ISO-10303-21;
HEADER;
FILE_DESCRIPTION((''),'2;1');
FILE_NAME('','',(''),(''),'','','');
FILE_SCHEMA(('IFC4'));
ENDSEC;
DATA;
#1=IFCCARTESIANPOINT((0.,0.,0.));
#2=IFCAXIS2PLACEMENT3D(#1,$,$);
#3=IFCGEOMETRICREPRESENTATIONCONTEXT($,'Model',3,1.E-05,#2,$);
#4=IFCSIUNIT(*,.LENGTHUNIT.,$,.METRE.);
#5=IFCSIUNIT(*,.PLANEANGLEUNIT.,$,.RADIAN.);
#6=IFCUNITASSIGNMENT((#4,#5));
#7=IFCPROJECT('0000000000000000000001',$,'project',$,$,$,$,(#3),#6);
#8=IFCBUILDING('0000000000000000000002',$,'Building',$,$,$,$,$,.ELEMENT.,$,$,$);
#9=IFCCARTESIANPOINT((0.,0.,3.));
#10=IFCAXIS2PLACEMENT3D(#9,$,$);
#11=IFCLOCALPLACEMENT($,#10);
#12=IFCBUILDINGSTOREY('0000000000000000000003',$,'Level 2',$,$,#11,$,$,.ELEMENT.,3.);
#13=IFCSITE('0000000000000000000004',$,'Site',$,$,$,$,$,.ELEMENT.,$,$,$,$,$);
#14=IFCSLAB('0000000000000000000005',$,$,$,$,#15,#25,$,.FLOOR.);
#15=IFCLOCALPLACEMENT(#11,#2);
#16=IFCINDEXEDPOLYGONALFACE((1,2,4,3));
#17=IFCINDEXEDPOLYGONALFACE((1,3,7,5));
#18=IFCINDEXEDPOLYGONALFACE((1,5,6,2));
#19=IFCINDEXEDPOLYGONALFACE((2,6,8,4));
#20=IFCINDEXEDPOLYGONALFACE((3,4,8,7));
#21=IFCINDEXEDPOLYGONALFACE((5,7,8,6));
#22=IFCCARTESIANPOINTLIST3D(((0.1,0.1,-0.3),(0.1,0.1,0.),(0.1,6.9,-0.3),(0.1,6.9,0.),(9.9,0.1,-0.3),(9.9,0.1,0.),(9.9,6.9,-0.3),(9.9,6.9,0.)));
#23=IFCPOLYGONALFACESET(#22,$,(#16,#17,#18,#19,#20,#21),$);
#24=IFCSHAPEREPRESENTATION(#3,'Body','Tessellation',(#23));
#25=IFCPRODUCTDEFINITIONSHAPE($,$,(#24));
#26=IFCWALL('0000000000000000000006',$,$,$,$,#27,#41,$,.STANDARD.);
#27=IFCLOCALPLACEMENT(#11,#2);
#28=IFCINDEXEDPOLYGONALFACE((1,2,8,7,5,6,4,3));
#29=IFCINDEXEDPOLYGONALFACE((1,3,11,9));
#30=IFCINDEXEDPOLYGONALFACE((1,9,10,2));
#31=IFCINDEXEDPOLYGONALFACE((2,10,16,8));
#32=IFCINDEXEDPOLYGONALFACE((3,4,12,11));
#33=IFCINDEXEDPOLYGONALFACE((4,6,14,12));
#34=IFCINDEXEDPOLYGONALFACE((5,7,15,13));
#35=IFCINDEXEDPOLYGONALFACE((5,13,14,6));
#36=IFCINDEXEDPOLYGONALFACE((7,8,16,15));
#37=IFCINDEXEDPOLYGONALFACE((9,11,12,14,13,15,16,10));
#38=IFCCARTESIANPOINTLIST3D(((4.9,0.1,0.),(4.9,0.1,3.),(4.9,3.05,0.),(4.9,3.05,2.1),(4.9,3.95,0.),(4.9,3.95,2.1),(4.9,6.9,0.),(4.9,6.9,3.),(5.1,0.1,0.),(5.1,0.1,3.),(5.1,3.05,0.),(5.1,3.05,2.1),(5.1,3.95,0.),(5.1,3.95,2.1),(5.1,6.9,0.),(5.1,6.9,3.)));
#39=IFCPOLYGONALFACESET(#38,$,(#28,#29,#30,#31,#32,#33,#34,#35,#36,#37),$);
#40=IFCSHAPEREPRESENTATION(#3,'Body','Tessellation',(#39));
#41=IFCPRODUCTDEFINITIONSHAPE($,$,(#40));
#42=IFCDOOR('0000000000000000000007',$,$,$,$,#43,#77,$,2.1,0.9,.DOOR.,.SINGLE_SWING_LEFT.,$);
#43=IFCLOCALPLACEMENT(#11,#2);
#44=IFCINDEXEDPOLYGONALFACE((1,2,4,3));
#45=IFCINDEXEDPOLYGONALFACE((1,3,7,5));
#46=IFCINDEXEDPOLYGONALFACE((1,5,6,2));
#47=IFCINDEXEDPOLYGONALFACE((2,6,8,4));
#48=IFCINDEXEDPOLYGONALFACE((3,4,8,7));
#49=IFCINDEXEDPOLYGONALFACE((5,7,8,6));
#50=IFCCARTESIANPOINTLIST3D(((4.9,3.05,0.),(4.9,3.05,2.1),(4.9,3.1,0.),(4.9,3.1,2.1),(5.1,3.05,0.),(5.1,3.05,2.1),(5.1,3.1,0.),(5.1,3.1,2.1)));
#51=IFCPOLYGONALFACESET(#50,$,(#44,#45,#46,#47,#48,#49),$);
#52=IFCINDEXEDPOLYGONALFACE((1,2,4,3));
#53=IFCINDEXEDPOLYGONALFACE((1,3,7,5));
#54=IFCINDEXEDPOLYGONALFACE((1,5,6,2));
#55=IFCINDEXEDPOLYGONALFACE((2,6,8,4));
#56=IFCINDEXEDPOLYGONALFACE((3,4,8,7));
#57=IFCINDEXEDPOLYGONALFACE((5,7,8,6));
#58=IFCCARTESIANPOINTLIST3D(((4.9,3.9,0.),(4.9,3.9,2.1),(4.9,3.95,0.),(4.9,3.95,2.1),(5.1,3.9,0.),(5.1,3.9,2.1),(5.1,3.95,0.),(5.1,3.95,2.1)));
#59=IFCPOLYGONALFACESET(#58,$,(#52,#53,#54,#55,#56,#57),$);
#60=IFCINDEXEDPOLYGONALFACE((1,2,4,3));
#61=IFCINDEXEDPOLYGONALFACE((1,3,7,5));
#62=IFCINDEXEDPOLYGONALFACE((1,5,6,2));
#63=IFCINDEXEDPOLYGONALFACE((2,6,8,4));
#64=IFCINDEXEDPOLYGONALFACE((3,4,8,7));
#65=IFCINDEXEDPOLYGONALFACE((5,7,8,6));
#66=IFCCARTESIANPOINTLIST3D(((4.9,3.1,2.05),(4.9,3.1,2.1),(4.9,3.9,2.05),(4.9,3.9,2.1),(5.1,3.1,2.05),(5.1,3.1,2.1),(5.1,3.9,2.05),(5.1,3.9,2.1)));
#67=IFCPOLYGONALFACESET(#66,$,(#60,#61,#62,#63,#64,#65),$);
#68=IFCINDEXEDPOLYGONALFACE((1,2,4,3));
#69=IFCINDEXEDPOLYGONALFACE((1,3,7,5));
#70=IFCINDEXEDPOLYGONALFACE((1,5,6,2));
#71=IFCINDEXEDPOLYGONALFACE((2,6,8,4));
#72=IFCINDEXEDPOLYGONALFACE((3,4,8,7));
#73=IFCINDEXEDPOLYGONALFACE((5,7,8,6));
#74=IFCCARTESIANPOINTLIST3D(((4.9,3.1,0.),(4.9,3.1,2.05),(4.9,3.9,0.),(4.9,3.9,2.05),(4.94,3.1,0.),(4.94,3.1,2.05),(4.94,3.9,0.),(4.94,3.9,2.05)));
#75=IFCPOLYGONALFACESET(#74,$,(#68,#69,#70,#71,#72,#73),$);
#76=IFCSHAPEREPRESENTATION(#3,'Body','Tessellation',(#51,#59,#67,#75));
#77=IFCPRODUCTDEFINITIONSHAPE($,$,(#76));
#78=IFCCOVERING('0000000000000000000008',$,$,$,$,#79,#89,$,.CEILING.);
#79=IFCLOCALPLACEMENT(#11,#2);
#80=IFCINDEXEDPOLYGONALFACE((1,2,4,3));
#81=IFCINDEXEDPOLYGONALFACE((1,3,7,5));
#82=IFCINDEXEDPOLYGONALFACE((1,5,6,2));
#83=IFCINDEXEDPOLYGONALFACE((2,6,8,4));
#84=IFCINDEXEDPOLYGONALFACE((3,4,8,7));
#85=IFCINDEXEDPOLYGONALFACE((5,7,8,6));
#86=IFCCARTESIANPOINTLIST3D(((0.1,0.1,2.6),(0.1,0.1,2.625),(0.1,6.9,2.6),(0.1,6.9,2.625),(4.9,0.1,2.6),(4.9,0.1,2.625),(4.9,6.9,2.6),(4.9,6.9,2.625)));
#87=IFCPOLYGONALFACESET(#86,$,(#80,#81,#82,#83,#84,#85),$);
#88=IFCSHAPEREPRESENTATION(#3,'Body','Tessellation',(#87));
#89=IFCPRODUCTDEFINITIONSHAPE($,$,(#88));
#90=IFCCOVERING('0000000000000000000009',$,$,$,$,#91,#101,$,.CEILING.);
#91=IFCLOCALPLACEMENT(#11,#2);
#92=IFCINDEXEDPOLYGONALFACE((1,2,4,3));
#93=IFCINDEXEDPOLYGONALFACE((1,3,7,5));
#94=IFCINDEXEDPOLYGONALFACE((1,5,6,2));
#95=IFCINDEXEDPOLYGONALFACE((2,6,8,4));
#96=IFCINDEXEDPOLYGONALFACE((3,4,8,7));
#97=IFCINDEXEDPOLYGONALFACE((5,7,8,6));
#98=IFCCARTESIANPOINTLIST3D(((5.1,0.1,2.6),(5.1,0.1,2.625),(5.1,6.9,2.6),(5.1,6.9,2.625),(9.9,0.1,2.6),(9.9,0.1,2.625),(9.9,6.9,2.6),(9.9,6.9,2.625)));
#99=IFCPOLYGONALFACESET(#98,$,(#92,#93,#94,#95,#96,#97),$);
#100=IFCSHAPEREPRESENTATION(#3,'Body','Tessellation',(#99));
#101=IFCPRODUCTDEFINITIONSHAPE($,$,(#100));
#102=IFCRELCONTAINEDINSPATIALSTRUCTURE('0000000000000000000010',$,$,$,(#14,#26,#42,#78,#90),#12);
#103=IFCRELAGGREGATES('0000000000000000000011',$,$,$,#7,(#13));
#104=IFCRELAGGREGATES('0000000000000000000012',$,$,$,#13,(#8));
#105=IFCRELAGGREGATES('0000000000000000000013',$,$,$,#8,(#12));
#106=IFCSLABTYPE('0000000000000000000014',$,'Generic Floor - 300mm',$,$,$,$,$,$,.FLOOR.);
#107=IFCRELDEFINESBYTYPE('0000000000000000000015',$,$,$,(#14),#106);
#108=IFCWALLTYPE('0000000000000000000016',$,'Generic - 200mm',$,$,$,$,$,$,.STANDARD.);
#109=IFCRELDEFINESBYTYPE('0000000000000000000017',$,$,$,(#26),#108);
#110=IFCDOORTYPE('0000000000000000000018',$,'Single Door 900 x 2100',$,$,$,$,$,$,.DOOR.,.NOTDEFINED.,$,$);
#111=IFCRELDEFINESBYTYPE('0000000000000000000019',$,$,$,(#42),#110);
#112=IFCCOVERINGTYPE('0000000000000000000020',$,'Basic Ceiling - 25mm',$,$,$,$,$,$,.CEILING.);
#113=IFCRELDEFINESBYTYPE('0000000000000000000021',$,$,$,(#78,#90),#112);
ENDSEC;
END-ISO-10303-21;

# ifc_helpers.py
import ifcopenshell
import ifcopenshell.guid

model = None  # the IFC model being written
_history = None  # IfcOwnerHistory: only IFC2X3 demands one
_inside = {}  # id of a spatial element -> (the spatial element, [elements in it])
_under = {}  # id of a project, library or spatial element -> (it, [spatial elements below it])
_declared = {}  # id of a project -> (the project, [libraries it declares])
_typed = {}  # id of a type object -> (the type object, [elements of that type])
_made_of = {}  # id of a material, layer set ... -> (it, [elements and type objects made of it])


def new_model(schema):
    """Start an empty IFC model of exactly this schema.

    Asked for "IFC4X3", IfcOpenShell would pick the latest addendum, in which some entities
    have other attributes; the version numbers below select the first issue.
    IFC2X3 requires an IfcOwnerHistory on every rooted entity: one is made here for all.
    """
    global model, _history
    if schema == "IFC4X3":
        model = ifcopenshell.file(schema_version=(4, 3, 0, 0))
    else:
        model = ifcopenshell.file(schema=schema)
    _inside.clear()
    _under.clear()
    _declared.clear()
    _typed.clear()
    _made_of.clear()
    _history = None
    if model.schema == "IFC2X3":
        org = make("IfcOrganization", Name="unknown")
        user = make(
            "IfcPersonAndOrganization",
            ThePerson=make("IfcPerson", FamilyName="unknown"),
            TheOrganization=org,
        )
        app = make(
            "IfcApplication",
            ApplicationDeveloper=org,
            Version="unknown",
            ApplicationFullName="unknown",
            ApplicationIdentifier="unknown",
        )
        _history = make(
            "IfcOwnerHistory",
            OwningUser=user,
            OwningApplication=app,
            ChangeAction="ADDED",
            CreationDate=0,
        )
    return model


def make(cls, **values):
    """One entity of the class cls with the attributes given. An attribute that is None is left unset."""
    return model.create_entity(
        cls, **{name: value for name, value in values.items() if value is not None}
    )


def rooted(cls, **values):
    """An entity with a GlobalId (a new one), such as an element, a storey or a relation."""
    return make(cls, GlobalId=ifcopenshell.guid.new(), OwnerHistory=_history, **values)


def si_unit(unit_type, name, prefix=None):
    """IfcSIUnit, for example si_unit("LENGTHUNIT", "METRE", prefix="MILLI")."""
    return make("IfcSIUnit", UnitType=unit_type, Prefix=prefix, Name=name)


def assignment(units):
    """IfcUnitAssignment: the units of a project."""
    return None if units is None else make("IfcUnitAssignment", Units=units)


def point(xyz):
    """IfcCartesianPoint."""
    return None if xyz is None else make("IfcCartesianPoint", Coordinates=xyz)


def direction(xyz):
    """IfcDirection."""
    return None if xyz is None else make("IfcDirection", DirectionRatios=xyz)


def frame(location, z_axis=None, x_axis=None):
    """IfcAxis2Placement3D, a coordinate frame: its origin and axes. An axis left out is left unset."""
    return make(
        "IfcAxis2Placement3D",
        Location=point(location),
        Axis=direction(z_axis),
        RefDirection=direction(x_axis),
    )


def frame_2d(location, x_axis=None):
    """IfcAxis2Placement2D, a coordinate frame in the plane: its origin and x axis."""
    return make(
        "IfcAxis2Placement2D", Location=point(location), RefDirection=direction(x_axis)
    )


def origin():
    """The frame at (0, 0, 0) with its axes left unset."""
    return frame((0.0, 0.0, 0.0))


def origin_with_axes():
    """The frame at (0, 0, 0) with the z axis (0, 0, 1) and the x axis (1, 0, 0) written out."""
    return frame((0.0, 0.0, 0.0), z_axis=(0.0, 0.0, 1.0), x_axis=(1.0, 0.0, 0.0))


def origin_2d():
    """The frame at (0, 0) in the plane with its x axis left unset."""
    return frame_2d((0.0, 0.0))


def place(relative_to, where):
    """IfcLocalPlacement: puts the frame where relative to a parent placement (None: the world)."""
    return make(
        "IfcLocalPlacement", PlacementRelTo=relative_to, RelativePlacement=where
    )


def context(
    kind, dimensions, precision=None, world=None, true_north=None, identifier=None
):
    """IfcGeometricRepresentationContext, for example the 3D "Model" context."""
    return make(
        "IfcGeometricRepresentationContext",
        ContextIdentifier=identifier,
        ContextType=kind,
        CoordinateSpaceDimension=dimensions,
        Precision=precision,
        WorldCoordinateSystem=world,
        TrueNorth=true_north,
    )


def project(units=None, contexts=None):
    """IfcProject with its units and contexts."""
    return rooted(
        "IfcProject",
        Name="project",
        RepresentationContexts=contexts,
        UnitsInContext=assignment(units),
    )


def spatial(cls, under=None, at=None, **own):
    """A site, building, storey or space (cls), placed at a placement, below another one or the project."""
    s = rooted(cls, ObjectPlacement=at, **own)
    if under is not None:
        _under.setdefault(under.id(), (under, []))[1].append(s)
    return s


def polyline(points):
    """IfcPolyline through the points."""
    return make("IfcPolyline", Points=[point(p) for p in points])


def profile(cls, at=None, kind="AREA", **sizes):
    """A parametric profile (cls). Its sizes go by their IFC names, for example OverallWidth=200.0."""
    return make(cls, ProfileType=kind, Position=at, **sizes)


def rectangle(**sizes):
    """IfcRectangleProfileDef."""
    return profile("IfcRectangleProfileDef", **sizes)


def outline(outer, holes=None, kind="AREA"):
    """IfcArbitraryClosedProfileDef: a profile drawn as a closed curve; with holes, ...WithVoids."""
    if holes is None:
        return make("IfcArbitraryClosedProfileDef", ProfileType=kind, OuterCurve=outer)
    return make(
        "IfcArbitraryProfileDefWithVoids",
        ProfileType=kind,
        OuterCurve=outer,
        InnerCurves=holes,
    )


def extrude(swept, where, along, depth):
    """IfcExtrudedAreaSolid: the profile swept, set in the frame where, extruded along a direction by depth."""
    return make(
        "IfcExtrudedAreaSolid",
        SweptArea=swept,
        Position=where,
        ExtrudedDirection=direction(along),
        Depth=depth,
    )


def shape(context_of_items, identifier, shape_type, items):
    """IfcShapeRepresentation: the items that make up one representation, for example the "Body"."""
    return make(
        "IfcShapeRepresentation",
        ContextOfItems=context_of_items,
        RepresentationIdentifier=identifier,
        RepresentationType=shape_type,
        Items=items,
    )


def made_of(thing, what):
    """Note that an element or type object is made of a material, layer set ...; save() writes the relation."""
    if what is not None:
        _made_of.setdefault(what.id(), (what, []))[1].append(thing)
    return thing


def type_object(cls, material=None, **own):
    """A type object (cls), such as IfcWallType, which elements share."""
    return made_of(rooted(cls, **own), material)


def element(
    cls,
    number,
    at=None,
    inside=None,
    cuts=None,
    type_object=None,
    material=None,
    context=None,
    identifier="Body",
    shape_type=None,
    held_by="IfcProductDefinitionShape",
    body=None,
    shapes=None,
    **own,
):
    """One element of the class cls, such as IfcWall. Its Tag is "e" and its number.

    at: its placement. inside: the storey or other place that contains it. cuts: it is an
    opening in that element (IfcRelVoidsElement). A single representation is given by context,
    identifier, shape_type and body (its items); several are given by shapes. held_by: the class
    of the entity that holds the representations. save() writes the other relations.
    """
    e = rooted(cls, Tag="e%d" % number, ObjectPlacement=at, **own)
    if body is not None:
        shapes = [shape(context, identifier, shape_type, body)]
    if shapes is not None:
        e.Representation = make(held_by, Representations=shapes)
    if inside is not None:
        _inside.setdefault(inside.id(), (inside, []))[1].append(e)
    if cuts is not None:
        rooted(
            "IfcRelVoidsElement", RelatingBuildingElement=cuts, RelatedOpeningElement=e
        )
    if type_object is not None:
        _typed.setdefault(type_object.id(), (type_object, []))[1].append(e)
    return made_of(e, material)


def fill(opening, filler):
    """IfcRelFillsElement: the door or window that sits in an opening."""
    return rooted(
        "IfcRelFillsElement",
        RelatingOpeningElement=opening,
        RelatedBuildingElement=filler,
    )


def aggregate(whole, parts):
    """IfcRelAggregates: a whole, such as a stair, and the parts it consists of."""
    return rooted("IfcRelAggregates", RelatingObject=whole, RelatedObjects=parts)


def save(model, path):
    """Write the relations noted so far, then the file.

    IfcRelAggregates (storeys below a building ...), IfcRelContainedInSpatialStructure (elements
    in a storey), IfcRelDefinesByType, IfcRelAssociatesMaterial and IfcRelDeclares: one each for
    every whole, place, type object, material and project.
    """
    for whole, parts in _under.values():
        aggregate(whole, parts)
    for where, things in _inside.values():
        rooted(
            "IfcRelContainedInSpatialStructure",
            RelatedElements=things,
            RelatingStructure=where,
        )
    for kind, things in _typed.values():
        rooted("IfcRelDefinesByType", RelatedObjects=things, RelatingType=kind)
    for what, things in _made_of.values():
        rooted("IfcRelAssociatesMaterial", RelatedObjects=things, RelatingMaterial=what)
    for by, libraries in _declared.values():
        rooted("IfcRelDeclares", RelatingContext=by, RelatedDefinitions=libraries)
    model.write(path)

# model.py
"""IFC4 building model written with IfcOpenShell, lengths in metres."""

from ifc_helpers import new_model, si_unit, frame, frame_2d, origin, origin_with_axes, origin_2d, place, context, project, spatial, polyline, rectangle, outline, extrude, type_object, element, fill, save


model = new_model("IFC4")

# Units and contexts
model_context = context("Model", 3, precision=1e-05, world=origin())
ifc_project = project(units=[si_unit("LENGTHUNIT", "METRE"), si_unit("PLANEANGLEUNIT", "RADIAN")], contexts=[model_context])

# Site, building, storey
site = spatial("IfcSite", under=ifc_project, Name="Site", CompositionType="ELEMENT")
building = spatial("IfcBuilding", under=site, Name="Building", CompositionType="ELEMENT")
storey_placement = place(None, frame((0.0, 0.0, 3.0)))
storey = spatial("IfcBuildingStorey", under=building, at=storey_placement, Name="Level 2", CompositionType="ELEMENT", Elevation=3.0)

# Slab
slab_type = type_object("IfcSlabType", Name="Generic Floor - 300mm", PredefinedType="FLOOR")
slab_placement = place(None, frame((0.0, 0.0, 3.0)))
element("IfcSlab", 1, at=slab_placement, inside=storey, type_object=slab_type, PredefinedType="FLOOR", context=model_context, shape_type="SweptSolid", body=[
    extrude(outline(polyline([(0.1, 0.1), (9.9, 0.1), (9.9, 6.9), (0.1, 6.9), (0.1, 0.1)])), origin(), (0.0, 0.0, -1.0), 0.3),
])

# Wall, opening, door
wall_type = type_object("IfcWallType", Name="Generic - 200mm", PredefinedType="STANDARD")
wall_placement = place(None, frame((5.0, 0.0, 3.0), z_axis=(0.0, 0.0, 1.0), x_axis=(0.0, 1.0, 0.0)))
wall = element("IfcWall", 2, at=wall_placement, inside=storey, type_object=wall_type, PredefinedType="STANDARD", context=model_context, shape_type="SweptSolid", body=[
    extrude(outline(polyline([(0.1, -0.1), (6.9, -0.1), (6.9, 0.1), (0.1, 0.1), (0.1, -0.1)])), origin(), (0.0, 0.0, 1.0), 3.0),
])
opening_placement = place(wall_placement, frame((3.5, 0.0, 0.0), z_axis=(0.0, 0.0, 1.0), x_axis=(1.0, 0.0, 0.0)))
opening = element("IfcOpeningElement", 3, at=opening_placement, cuts=wall, PredefinedType="OPENING", context=model_context, shape_type="SweptSolid", body=[
    extrude(rectangle(XDim=0.9, YDim=0.202, at=origin_2d()), origin(), (0.0, 0.0, 1.0), 2.1),
])
door_type = type_object("IfcDoorType", Name="Single Door 900 x 2100", OperationType="NOTDEFINED", PredefinedType="DOOR")
door_placement = place(opening_placement, origin_with_axes())
door = element("IfcDoor", 4, at=door_placement, inside=storey, type_object=door_type, OperationType="SINGLE_SWING_LEFT", OverallHeight=2.1, OverallWidth=0.9, PredefinedType="DOOR", context=model_context, shape_type="SweptSolid", body=[
    extrude(rectangle(XDim=0.05, YDim=0.2, at=frame_2d((-0.425, 0.0))), origin(), (0.0, 0.0, 1.0), 2.1),
    extrude(rectangle(XDim=0.05, YDim=0.2, at=frame_2d((0.425, 0.0))), origin(), (0.0, 0.0, 1.0), 2.1),
    extrude(rectangle(XDim=0.8, YDim=0.2, at=origin_2d()), frame((0.0, 0.0, 2.05)), (0.0, 0.0, 1.0), 0.05),
    extrude(rectangle(XDim=0.8, YDim=0.04, at=frame_2d((0.0, 0.08))), origin(), (0.0, 0.0, 1.0), 2.05),
])
fill(opening, door)

# Coverings
covering_type = type_object("IfcCoveringType", Name="Basic Ceiling - 25mm", PredefinedType="CEILING")
covering_1_placement = place(None, frame((0.0, 0.0, 5.625)))
element("IfcCovering", 5, at=covering_1_placement, inside=storey, type_object=covering_type, PredefinedType="CEILING", context=model_context, shape_type="SweptSolid", body=[
    extrude(outline(polyline([(0.1, 0.1), (4.9, 0.1), (4.9, 6.9), (0.1, 6.9), (0.1, 0.1)])), origin(), (0.0, 0.0, -1.0), 0.025),
])
covering_2_placement = place(None, frame((0.0, 0.0, 5.625)))
element("IfcCovering", 6, at=covering_2_placement, inside=storey, type_object=covering_type, PredefinedType="CEILING", context=model_context, shape_type="SweptSolid", body=[
    extrude(outline(polyline([(5.1, 0.1), (9.9, 0.1), (9.9, 6.9), (5.1, 6.9), (5.1, 0.1)])), origin(), (0.0, 0.0, -1.0), 0.025),
])

save(model, "model.ifc")
